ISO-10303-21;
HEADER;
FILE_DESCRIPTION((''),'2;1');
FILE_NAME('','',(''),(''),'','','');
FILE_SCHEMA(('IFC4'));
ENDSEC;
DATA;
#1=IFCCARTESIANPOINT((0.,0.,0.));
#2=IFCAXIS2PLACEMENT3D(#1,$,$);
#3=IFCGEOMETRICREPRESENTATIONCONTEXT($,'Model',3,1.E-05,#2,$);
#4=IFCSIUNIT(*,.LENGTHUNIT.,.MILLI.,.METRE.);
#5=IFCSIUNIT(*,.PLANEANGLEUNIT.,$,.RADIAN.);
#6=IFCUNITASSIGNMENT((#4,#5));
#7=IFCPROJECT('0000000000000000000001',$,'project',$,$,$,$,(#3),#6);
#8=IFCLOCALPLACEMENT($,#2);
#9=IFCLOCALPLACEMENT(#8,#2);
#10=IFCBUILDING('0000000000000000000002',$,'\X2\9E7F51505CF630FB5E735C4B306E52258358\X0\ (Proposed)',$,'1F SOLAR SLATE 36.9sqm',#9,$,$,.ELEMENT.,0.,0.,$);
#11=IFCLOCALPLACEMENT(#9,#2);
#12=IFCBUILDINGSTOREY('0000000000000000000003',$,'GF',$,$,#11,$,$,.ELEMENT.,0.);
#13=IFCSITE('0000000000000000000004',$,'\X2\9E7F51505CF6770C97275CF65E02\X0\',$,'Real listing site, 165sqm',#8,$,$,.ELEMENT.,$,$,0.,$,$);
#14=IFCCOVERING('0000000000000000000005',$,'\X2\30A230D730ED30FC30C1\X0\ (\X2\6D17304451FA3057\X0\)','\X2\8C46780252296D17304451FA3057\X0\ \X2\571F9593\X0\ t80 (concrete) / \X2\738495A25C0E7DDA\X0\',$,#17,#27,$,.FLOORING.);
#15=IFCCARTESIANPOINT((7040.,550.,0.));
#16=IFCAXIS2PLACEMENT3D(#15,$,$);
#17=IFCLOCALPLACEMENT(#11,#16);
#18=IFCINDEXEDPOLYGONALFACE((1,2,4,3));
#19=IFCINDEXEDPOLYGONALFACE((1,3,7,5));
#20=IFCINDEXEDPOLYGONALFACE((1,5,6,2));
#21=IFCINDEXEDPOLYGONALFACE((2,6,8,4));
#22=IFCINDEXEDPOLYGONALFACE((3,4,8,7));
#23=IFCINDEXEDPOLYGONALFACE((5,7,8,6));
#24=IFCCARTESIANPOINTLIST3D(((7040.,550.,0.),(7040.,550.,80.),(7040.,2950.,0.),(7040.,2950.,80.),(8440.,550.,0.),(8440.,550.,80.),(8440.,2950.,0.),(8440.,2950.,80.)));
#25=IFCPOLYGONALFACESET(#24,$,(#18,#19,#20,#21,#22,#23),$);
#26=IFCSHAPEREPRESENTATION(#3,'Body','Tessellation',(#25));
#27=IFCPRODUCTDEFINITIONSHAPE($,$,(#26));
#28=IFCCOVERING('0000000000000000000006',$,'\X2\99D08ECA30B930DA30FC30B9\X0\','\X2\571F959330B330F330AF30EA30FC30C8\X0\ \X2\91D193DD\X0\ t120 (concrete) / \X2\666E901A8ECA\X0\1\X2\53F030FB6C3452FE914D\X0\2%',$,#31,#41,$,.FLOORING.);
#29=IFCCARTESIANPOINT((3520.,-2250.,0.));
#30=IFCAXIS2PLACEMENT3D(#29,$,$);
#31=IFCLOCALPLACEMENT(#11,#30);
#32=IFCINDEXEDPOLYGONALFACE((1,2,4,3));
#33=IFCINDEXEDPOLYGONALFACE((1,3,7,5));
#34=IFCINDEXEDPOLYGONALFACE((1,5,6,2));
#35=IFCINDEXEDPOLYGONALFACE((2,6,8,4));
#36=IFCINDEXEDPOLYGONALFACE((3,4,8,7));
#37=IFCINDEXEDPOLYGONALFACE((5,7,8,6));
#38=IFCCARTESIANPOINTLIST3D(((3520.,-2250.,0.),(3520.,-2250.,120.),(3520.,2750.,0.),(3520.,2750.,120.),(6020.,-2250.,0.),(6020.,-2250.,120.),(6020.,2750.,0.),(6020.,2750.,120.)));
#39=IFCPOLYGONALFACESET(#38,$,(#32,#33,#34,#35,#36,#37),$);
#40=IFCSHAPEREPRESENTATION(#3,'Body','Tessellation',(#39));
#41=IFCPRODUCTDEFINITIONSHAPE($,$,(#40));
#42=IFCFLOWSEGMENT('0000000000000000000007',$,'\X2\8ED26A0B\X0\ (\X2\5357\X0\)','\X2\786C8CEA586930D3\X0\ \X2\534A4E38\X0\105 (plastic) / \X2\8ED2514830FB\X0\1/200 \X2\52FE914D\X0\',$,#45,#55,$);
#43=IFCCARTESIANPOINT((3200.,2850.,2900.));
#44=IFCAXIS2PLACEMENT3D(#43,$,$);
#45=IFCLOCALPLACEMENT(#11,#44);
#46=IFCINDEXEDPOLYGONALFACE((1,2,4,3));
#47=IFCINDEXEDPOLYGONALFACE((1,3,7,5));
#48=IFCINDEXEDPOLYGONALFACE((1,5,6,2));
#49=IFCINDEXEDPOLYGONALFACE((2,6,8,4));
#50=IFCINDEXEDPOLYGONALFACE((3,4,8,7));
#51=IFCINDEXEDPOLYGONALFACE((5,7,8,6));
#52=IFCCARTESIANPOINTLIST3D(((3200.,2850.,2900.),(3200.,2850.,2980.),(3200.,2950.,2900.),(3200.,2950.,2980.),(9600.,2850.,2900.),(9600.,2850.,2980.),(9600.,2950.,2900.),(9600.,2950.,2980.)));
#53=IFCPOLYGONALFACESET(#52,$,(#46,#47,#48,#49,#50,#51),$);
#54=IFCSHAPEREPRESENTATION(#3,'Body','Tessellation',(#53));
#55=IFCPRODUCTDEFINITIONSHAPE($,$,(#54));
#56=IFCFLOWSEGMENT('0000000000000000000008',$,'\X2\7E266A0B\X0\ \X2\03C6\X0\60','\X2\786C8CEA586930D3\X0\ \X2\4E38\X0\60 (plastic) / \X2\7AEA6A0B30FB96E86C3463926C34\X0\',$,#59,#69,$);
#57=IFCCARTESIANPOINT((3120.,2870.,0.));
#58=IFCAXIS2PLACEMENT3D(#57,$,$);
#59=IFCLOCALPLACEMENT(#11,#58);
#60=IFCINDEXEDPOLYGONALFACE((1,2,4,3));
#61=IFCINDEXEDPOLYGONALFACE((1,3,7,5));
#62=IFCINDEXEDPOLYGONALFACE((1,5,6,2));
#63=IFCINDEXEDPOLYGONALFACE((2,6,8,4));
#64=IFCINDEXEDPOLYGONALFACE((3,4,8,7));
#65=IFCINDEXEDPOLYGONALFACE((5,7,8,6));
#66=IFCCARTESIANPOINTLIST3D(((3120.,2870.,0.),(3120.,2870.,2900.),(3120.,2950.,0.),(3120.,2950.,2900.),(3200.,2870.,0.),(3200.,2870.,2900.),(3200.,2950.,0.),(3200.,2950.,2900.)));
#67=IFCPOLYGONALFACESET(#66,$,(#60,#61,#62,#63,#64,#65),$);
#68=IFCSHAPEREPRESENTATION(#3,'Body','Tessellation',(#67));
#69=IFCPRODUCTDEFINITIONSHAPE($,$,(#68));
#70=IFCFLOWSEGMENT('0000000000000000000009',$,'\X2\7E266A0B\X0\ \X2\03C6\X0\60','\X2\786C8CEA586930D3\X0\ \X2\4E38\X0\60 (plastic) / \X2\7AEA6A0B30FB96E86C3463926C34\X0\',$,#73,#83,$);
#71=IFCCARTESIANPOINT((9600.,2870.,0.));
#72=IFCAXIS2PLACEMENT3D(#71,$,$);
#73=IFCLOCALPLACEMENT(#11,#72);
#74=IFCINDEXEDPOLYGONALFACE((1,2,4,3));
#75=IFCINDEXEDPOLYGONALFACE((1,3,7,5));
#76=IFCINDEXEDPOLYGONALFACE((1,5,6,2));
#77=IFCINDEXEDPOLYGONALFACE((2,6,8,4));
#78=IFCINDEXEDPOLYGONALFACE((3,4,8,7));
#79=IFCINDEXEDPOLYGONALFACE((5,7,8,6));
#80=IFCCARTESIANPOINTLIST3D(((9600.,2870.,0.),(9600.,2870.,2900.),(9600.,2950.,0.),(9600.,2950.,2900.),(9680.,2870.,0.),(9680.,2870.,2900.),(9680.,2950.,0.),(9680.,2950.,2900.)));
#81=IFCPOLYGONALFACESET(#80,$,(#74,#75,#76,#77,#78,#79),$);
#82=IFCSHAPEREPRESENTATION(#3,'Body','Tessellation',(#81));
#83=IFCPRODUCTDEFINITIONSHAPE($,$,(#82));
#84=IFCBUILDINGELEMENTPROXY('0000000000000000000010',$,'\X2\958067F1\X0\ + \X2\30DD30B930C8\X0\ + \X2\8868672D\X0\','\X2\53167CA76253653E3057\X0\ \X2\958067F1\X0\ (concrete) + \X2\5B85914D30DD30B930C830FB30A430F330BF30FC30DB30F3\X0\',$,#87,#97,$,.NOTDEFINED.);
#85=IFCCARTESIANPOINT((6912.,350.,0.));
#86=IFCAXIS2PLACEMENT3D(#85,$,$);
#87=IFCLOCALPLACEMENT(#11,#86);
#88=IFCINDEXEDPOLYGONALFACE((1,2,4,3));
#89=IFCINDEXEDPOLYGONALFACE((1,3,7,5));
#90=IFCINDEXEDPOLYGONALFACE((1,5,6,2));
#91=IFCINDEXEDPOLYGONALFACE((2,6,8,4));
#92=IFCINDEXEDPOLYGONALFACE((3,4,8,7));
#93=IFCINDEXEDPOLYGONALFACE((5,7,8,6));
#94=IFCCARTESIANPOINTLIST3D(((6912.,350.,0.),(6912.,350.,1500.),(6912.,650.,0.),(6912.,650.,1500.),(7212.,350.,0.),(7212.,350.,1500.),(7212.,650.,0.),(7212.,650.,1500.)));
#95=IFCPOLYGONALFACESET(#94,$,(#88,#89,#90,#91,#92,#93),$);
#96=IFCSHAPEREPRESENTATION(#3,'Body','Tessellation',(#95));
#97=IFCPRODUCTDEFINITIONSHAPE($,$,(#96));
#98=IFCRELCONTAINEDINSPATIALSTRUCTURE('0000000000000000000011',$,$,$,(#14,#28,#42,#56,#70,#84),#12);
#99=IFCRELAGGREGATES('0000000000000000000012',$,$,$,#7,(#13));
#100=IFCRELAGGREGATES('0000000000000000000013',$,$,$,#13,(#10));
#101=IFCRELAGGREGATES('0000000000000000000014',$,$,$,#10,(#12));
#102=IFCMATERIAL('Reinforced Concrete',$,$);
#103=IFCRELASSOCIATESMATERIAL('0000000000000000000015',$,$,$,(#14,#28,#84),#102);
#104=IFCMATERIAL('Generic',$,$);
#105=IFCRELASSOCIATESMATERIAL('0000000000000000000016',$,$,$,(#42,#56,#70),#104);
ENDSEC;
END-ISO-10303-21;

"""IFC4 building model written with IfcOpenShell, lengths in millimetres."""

from ifc_helpers import new_model, si_unit, frame, frame_2d, origin, place, context, project, spatial, rectangle, extrude, material, element, save


model = new_model("IFC4")

# Units and contexts
model_context = context("Model", 3, precision=1e-05, world=origin())
ifc_project = project(units=[si_unit("LENGTHUNIT", "METRE", prefix="MILLI"), si_unit("PLANEANGLEUNIT", "RADIAN")], contexts=[model_context])

# Site, building, storey
site_placement = place(None, origin())
site = spatial("IfcSite", under=ifc_project, at=site_placement, Name="鹿児島県霧島市", ObjectType="Real listing site, 165sqm", CompositionType="ELEMENT", RefElevation=0.0)
building_placement = place(site_placement, origin())
building = spatial("IfcBuilding", under=site, at=building_placement, Name="鹿児島・平屋の別荘 (Proposed)", ObjectType="1F SOLAR SLATE 36.9sqm", CompositionType="ELEMENT", ElevationOfRefHeight=0.0, ElevationOfTerrain=0.0)
storey_placement = place(building_placement, origin())
storey = spatial("IfcBuildingStorey", under=building, at=storey_placement, Name="GF", CompositionType="ELEMENT", Elevation=0.0)

# Shared definitions
ifc_material_1 = material(Name="Reinforced Concrete")

# Coverings
ifc_material_2 = material(Name="Generic")
covering_1_placement = place(storey_placement, frame((7040.0, 550.0, 0.0)))
element("IfcCovering", 1, at=covering_1_placement, inside=storey, material=ifc_material_1, Name="アプローチ (洗い出し)", Description="豆砂利洗い出し 土間 t80 (concrete) / 玄関導線", PredefinedType="FLOORING", context=model_context, shape_type="SweptSolid", body=[
    extrude(rectangle(XDim=1400.0, YDim=2400.0, at=frame_2d((700.0, 1200.0))), frame((7040.0, 550.0, 0.0)), (0.0, 0.0, 1.0), 80.0),
])
covering_2_placement = place(storey_placement, frame((3520.0, -2250.0, 0.0)))
element("IfcCovering", 2, at=covering_2_placement, inside=storey, material=ifc_material_1, Name="駐車スペース", Description="土間コンクリート 金鏝 t120 (concrete) / 普通車1台・水勾配2%", PredefinedType="FLOORING", context=model_context, shape_type="SweptSolid", body=[
    extrude(rectangle(XDim=2500.0, YDim=5000.0, at=frame_2d((1250.0, 2500.0))), frame((3520.0, -2250.0, 0.0)), (0.0, 0.0, 1.0), 120.0),
])

# Flow segments
flow_segment_1_placement = place(storey_placement, frame((3200.0, 2850.0, 2900.0)))
element("IfcFlowSegment", 3, at=flow_segment_1_placement, inside=storey, material=ifc_material_2, Name="軒樋 (南)", Description="硬質塩ビ 半丸105 (plastic) / 軒先・1/200 勾配", context=model_context, shape_type="SweptSolid", body=[
    extrude(rectangle(XDim=6400.0, YDim=100.0, at=frame_2d((3200.0, 50.0))), frame((3200.0, 2850.0, 2900.0)), (0.0, 0.0, 1.0), 80.0),
])
flow_segment_2_placement = place(storey_placement, frame((3120.0, 2870.0, 0.0)))
element("IfcFlowSegment", 4, at=flow_segment_2_placement, inside=storey, material=ifc_material_2, Name="縦樋 φ60", Description="硬質塩ビ 丸60 (plastic) / 竪樋・雨水排水", context=model_context, shape_type="SweptSolid", body=[
    extrude(rectangle(XDim=80.0, YDim=80.0, at=frame_2d((40.0, 40.0))), frame((3120.0, 2870.0, 0.0)), (0.0, 0.0, 1.0), 2900.0),
])
flow_segment_3_placement = place(storey_placement, frame((9600.0, 2870.0, 0.0)))
element("IfcFlowSegment", 5, at=flow_segment_3_placement, inside=storey, material=ifc_material_2, Name="縦樋 φ60", Description="硬質塩ビ 丸60 (plastic) / 竪樋・雨水排水", context=model_context, shape_type="SweptSolid", body=[
    extrude(rectangle(XDim=80.0, YDim=80.0, at=frame_2d((40.0, 40.0))), frame((9600.0, 2870.0, 0.0)), (0.0, 0.0, 1.0), 2900.0),
])

# Building element proxy
proxy_placement = place(storey_placement, frame((6912.0, 350.0, 0.0)))
element("IfcBuildingElementProxy", 6, at=proxy_placement, inside=storey, material=ifc_material_1, Name="門柱 + ポスト + 表札", Description="化粧打放し 門柱 (concrete) + 宅配ポスト・インターホン", PredefinedType="NOTDEFINED", context=model_context, shape_type="SweptSolid", body=[
    extrude(rectangle(XDim=300.0, YDim=300.0, at=frame_2d((150.0, 150.0))), frame((6912.0, 350.0, 0.0)), (0.0, 0.0, 1.0), 1500.0),
])

save(model, "model.ifc")
